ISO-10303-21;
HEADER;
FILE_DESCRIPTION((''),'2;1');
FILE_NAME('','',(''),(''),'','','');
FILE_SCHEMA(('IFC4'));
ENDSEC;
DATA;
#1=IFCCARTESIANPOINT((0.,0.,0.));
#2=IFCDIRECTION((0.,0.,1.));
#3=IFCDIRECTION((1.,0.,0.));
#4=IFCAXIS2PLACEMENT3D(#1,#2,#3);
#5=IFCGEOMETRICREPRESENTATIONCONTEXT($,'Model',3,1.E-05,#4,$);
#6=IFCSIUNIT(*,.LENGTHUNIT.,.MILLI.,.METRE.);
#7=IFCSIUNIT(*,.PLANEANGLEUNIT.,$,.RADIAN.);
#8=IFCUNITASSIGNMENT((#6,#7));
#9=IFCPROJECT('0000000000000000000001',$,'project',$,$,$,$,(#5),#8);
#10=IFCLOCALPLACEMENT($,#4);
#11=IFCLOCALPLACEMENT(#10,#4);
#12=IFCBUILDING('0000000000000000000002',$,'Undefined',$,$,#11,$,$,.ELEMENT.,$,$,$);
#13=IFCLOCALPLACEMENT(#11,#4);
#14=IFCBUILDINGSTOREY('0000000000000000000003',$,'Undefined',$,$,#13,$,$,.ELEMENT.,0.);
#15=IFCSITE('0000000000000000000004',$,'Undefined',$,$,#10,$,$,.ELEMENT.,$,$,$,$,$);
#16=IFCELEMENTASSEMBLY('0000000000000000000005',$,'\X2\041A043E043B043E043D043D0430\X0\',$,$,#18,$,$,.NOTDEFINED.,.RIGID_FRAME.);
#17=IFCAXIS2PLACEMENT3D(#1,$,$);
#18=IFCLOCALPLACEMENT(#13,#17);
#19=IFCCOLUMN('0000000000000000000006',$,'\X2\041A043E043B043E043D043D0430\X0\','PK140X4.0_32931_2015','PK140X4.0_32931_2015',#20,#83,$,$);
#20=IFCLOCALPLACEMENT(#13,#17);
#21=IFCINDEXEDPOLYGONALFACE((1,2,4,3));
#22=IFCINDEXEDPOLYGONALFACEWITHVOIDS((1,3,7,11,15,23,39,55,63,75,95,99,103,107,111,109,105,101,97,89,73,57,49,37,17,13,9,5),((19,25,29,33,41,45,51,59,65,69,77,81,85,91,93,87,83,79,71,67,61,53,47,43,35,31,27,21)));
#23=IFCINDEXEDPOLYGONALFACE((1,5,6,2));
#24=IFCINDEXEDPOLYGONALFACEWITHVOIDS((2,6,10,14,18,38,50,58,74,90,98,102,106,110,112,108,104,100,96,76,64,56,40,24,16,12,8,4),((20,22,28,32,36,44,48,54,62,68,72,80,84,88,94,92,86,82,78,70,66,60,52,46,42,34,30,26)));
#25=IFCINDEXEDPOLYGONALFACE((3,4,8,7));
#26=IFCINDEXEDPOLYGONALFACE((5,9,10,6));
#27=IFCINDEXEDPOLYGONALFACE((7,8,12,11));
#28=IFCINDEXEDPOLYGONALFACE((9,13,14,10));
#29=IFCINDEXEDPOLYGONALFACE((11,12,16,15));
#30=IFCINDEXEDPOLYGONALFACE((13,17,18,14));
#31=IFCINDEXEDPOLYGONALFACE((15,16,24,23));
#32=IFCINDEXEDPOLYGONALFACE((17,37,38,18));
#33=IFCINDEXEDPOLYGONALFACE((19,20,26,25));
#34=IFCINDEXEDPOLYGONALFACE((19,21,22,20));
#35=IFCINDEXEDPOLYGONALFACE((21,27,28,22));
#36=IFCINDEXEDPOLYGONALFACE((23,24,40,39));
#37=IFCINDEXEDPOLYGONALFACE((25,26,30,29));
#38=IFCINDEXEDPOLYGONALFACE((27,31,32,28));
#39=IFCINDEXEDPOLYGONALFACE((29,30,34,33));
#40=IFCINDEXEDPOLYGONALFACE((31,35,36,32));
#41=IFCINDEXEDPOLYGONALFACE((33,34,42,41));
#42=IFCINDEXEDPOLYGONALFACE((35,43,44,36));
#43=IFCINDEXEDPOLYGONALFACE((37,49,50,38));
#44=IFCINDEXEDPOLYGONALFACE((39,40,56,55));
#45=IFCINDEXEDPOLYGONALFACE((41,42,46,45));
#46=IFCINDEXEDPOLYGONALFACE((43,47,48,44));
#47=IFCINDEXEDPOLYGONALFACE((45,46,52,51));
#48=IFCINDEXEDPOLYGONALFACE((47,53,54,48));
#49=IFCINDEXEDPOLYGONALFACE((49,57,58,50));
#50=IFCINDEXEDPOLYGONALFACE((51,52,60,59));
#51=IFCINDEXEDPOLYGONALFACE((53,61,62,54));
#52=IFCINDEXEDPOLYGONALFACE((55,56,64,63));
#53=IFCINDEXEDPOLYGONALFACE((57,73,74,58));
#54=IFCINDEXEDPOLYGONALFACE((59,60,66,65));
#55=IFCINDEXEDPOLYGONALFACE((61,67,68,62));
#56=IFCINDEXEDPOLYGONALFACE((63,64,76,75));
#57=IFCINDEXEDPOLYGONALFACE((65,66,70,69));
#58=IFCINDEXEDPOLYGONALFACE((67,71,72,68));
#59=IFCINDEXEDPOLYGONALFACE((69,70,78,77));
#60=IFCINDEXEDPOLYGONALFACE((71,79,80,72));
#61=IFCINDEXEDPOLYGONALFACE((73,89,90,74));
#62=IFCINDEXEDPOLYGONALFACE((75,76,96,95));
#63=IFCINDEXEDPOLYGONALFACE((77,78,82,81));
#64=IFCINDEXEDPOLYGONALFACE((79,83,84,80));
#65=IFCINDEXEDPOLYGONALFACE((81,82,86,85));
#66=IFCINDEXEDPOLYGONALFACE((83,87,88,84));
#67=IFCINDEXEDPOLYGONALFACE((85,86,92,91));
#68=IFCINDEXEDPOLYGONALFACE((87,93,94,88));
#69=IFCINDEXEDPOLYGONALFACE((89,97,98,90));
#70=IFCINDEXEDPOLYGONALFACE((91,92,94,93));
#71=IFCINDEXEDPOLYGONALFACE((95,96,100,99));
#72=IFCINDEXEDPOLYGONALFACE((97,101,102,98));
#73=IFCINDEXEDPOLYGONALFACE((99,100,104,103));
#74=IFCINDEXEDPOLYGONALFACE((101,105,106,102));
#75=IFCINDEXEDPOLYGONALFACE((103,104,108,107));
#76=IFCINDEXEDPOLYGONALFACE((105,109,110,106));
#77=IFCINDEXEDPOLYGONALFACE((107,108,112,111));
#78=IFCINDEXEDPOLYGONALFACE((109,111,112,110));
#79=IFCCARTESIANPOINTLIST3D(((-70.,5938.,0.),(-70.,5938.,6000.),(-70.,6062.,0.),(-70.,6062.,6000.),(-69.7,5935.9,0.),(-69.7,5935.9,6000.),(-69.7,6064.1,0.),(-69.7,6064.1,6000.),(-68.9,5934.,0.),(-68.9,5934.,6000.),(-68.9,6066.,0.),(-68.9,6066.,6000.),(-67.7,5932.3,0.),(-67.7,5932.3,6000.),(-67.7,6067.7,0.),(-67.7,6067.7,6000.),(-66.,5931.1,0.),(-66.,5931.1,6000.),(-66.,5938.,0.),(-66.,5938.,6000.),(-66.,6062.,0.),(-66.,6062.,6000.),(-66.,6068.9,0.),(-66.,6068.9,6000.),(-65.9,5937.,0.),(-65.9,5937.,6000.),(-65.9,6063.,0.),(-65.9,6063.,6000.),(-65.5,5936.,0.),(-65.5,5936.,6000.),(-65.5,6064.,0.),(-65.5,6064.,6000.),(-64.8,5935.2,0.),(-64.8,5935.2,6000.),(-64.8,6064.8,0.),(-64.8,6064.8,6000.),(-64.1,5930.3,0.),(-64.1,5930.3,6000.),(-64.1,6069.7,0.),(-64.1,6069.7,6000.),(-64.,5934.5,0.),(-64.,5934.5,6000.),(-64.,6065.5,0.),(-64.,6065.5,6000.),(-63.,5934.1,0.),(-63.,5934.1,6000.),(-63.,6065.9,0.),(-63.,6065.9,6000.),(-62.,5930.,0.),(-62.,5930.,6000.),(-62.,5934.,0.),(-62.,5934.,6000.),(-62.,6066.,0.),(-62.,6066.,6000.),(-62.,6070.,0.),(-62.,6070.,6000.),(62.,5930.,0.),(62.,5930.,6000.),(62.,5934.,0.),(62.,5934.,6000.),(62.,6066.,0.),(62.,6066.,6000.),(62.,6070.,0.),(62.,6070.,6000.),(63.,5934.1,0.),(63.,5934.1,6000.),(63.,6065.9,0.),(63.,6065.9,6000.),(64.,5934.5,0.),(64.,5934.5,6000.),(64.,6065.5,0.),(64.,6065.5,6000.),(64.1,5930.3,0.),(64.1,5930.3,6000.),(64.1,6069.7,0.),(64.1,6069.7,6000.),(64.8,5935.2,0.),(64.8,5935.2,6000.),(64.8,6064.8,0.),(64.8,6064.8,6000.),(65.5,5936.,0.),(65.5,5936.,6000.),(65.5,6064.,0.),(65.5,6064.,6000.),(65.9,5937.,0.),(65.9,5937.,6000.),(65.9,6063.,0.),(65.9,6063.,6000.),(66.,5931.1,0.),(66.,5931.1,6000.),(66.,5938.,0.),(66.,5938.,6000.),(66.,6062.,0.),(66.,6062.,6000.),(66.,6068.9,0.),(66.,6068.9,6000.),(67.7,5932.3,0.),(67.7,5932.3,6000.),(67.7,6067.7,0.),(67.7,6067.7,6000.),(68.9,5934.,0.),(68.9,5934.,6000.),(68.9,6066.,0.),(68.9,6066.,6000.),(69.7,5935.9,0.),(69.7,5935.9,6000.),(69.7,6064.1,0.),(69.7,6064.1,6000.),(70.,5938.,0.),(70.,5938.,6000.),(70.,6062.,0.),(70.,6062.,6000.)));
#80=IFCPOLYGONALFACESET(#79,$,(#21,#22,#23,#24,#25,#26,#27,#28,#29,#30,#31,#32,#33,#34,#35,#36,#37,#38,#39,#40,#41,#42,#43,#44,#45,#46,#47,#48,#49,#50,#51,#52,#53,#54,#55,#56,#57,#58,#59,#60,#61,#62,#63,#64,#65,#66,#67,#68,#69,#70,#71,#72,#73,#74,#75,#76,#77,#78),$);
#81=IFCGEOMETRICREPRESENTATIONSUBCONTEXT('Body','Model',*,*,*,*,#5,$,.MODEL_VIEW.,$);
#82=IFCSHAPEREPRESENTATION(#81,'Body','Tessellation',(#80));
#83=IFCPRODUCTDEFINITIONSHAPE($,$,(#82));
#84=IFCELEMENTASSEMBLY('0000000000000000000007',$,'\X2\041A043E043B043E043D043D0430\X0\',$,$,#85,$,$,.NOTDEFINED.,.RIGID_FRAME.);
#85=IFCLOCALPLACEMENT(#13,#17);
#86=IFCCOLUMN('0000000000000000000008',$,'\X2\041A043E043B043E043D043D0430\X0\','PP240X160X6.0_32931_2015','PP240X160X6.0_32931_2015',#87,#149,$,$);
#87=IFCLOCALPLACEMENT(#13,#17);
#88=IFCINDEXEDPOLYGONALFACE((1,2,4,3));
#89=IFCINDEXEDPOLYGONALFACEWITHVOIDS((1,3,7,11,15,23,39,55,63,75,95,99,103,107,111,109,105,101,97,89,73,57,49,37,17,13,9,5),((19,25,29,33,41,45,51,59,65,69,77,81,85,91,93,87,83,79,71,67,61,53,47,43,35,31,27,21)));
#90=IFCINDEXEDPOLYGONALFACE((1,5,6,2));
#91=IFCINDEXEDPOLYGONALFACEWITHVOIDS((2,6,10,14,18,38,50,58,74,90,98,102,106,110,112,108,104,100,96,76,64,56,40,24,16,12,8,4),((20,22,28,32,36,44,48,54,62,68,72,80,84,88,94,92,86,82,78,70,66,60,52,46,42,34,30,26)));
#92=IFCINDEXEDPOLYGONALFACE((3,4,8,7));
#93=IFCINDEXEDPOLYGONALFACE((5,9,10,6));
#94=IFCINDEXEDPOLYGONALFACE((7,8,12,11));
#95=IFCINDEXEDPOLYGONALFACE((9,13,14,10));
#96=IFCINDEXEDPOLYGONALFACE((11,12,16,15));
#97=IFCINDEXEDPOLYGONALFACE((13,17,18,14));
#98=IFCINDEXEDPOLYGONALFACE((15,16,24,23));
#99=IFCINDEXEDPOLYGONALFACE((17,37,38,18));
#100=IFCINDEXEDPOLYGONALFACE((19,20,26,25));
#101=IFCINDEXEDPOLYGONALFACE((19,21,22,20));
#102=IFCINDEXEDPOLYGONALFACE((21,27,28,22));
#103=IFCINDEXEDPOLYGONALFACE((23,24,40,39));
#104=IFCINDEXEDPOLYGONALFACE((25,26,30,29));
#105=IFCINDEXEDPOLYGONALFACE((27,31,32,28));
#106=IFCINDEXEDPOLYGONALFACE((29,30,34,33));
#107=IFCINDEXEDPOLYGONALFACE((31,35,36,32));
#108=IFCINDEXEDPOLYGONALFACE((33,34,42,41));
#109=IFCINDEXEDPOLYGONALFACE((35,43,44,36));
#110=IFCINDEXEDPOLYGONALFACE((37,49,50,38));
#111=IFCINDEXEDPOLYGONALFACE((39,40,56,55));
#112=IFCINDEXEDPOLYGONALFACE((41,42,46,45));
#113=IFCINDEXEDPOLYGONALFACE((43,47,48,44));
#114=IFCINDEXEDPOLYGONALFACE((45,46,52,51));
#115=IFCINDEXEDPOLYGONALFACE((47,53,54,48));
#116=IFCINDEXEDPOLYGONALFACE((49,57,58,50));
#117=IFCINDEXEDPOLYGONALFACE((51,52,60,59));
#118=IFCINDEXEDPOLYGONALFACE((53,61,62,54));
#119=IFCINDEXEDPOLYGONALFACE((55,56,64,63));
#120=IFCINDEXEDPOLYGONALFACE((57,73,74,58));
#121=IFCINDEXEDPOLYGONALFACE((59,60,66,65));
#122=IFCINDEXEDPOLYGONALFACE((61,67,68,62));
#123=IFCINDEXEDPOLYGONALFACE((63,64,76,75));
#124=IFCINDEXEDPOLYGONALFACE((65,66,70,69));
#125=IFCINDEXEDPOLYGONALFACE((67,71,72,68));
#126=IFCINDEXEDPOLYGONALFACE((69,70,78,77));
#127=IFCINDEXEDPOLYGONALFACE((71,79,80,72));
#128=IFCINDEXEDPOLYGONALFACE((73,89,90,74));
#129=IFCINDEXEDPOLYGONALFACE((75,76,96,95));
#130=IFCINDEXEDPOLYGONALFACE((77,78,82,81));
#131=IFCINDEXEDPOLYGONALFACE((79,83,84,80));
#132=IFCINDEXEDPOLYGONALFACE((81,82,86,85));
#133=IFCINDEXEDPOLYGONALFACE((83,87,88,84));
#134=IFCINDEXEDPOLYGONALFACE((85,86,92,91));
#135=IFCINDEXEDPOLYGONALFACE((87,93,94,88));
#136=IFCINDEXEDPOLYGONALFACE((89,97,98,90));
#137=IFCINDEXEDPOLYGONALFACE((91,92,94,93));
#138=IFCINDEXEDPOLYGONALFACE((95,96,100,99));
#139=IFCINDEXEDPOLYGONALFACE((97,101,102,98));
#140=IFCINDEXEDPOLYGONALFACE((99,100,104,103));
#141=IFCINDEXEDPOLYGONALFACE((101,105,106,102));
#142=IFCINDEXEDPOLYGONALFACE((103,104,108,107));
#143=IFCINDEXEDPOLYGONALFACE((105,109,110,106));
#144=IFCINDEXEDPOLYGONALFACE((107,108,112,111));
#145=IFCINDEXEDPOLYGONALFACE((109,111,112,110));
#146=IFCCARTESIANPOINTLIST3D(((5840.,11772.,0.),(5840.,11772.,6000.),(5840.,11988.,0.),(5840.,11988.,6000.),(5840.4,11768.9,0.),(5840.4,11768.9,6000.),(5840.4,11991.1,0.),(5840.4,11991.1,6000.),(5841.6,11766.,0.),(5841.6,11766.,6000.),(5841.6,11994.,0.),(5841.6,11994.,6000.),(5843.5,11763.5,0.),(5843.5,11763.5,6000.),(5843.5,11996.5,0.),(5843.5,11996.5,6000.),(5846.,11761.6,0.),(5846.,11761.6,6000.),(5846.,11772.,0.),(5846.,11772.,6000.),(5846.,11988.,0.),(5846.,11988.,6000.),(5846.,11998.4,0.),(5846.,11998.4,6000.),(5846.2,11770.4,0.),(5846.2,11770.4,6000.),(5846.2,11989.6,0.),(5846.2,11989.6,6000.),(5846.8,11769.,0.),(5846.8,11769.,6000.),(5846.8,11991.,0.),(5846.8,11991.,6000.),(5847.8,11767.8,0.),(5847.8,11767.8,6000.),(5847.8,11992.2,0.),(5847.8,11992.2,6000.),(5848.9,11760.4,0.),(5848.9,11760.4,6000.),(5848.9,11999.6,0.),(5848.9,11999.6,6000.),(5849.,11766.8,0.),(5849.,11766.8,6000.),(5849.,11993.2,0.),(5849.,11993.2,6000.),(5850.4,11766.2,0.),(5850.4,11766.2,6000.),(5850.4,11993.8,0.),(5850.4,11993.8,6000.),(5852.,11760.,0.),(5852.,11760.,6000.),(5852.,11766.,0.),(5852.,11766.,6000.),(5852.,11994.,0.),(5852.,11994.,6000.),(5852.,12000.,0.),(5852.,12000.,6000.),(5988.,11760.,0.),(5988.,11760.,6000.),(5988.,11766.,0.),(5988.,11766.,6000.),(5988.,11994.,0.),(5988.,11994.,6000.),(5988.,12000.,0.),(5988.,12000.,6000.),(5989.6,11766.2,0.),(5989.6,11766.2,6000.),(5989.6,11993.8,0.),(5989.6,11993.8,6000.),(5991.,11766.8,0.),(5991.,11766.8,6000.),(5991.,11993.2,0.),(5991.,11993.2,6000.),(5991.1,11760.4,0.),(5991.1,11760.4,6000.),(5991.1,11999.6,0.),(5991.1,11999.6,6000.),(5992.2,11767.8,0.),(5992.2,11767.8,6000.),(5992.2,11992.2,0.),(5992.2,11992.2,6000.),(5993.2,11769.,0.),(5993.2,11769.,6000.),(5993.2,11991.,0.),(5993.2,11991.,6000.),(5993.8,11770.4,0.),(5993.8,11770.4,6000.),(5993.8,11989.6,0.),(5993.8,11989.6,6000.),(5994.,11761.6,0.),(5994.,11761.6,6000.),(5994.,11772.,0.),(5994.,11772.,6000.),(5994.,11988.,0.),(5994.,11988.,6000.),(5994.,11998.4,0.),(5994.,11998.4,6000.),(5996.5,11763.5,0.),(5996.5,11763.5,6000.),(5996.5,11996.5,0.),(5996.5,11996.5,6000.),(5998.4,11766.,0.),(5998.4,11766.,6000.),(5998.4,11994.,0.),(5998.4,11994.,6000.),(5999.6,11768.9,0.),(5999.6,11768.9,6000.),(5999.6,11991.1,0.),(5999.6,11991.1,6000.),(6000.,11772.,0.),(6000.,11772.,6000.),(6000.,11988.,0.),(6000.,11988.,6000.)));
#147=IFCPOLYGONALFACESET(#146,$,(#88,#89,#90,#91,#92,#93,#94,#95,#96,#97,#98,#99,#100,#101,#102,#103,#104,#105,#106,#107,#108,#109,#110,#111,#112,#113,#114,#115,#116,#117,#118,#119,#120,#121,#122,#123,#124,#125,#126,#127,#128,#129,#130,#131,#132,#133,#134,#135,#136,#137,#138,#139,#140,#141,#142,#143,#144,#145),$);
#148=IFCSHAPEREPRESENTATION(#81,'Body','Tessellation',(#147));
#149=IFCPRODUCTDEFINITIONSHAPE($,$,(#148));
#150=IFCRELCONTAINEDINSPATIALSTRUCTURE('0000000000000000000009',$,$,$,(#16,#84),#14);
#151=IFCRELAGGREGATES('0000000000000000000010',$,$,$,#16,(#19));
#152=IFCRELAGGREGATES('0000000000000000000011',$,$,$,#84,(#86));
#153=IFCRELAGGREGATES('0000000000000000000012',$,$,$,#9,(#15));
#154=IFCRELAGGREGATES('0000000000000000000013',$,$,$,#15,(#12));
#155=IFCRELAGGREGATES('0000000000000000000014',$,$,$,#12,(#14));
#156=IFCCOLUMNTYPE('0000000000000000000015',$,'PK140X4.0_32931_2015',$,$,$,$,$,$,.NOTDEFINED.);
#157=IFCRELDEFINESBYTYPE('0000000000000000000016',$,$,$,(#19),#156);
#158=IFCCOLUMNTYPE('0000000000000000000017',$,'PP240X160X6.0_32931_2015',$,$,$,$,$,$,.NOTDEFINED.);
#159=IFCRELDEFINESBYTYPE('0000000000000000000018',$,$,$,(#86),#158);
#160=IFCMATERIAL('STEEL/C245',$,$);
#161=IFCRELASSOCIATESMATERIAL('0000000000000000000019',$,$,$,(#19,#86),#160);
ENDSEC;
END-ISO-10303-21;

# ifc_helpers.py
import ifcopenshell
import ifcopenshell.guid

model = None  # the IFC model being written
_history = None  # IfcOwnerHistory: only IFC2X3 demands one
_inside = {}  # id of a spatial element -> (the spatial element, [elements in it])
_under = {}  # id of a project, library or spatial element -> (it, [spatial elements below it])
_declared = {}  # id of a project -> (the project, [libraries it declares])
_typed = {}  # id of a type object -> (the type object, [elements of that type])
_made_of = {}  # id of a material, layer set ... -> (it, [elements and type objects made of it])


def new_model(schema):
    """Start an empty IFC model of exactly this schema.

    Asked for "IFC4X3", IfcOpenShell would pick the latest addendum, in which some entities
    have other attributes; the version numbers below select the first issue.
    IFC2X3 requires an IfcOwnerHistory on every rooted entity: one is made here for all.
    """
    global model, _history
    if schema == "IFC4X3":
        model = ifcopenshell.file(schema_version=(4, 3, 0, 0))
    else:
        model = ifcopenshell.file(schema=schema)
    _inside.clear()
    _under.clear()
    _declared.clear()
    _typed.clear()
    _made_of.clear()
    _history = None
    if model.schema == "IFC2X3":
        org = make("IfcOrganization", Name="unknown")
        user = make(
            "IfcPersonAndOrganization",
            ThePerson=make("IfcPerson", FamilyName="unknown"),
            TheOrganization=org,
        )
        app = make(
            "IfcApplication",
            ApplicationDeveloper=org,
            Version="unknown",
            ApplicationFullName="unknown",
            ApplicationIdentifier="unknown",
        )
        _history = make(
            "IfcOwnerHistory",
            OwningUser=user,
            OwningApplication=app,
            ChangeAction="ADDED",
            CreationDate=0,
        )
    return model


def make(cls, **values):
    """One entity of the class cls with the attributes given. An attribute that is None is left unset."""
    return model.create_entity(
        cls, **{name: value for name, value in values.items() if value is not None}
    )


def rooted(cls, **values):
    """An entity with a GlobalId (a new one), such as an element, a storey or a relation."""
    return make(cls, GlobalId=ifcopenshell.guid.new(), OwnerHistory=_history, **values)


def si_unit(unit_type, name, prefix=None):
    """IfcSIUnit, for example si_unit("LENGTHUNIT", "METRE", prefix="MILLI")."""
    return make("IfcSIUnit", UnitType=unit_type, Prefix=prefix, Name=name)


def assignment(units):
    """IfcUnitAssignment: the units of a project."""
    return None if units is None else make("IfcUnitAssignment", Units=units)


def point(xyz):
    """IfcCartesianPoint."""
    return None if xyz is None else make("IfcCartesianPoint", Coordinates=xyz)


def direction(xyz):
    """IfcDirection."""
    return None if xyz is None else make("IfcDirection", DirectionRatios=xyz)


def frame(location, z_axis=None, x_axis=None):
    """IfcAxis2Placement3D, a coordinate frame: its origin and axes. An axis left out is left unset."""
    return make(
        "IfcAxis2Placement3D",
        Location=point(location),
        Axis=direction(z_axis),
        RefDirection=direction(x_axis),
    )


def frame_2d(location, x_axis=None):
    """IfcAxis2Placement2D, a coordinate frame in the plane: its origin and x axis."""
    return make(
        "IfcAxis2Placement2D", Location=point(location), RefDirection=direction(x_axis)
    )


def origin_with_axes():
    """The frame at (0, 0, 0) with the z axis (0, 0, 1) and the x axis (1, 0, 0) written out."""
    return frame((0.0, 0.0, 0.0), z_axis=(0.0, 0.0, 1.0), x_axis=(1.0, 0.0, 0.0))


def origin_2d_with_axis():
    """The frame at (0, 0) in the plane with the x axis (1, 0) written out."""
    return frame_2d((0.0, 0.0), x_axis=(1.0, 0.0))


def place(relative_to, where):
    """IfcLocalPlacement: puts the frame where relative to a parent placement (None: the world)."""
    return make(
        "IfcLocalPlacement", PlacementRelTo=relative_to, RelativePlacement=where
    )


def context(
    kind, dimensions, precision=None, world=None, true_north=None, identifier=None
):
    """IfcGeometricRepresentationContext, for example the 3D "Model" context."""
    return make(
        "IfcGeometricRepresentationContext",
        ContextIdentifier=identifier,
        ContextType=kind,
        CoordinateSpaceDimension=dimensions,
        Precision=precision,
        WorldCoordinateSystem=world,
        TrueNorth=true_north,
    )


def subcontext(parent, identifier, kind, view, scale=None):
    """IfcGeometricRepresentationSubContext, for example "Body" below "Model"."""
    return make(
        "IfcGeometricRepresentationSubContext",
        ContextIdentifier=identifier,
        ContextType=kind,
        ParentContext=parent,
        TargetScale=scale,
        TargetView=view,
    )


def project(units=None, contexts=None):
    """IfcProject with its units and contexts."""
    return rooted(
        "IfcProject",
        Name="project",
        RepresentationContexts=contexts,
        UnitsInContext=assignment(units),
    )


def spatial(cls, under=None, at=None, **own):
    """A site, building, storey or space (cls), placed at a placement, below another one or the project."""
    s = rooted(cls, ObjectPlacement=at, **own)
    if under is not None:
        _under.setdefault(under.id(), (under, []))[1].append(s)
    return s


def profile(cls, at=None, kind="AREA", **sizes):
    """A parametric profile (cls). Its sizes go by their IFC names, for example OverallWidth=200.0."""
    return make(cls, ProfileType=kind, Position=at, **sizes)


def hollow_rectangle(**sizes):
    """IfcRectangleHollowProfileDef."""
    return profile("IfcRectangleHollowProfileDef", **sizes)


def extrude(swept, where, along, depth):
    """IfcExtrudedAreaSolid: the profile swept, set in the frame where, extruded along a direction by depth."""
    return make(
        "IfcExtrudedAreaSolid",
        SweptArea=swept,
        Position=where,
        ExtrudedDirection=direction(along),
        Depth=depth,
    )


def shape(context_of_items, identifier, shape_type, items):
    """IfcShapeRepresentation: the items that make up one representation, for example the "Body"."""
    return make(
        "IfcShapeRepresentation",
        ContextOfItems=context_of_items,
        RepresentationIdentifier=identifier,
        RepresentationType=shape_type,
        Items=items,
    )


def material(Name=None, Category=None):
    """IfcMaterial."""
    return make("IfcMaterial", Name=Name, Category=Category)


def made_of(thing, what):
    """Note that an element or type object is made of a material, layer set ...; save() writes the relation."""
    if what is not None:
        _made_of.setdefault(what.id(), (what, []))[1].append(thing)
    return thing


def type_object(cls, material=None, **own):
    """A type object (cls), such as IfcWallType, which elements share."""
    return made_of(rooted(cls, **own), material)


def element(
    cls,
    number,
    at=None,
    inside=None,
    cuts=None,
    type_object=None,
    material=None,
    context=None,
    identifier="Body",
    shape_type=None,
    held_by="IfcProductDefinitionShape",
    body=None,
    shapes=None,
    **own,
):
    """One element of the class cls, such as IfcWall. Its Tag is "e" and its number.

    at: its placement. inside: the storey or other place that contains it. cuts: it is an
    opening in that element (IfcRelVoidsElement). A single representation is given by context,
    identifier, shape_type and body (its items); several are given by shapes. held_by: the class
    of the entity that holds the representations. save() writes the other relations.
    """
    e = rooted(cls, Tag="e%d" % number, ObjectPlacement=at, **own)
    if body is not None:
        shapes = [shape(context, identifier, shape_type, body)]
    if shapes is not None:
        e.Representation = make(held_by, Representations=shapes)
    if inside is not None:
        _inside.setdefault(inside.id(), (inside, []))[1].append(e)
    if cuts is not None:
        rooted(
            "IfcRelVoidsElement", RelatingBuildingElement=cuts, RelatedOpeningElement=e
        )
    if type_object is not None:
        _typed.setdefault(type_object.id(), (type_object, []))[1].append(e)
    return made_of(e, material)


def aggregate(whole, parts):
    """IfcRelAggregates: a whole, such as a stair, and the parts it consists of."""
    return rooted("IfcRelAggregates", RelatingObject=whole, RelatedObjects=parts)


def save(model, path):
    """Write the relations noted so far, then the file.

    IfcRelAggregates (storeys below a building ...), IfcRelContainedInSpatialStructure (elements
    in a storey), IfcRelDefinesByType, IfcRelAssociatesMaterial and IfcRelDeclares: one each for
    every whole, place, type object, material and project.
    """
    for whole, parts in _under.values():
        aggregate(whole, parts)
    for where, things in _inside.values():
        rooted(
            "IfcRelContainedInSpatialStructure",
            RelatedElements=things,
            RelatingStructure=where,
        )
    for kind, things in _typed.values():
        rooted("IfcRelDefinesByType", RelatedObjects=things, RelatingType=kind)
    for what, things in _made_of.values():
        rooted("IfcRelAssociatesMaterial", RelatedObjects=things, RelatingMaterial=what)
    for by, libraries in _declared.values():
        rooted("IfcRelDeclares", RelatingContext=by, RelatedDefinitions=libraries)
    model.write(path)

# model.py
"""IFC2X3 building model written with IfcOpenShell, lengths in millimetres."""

from ifc_helpers import new_model, si_unit, frame, origin_with_axes, origin_2d_with_axis, place, context, subcontext, project, spatial, hollow_rectangle, extrude, material, type_object, element, aggregate, save


model = new_model("IFC2X3")

# Units and contexts
model_context = context("Model", 3, precision=1e-05, world=origin_with_axes())
body_context = subcontext(model_context, "Body", "Model", "MODEL_VIEW")
ifc_project = project(units=[si_unit("LENGTHUNIT", "METRE", prefix="MILLI"), si_unit("PLANEANGLEUNIT", "RADIAN")], contexts=[model_context])

# Site, building, storey
site_placement = place(None, origin_with_axes())
site = spatial("IfcSite", under=ifc_project, at=site_placement, Name="Undefined", CompositionType="ELEMENT")
building_placement = place(site_placement, origin_with_axes())
building = spatial("IfcBuilding", under=site, at=building_placement, Name="Undefined", CompositionType="ELEMENT")
storey_placement = place(building_placement, origin_with_axes())
storey = spatial("IfcBuildingStorey", under=building, at=storey_placement, Name="Undefined", CompositionType="ELEMENT", Elevation=0.0)

# Element assemblies, columns
assembly_1_placement = place(storey_placement, origin_with_axes())
assembly_1 = element("IfcElementAssembly", 1, at=assembly_1_placement, inside=storey, Name="Колонна", AssemblyPlace="NOTDEFINED", PredefinedType="RIGID_FRAME")
ifc_material = material(Name="STEEL/C245")
column_type_1 = type_object("IfcColumnType", Name="PK140X4.0_32931_2015", PredefinedType="NOTDEFINED")
column_1_placement = place(assembly_1_placement, frame((0.0, 6000.0, 0.0), z_axis=(0.0, 0.0, 1.0), x_axis=(0.0, 1.0, 0.0)))
column_1 = element("IfcColumn", 2, at=column_1_placement, type_object=column_type_1, material=ifc_material, Name="Колонна", Description="PK140X4.0_32931_2015", ObjectType="PK140X4.0_32931_2015", context=body_context, shape_type="SweptSolid", body=[
    extrude(hollow_rectangle(XDim=140.0, YDim=140.0, WallThickness=4.0, InnerFilletRadius=4.0, OuterFilletRadius=8.0, at=origin_2d_with_axis()), frame((0.0, 0.0, 6000.0), z_axis=(0.0, 0.0, -1.0), x_axis=(0.0, 1.0, 0.0)), (0.0, 0.0, 1.0), 6000.0),
])
aggregate(assembly_1, [column_1])
assembly_2_placement = place(storey_placement, origin_with_axes())
assembly_2 = element("IfcElementAssembly", 3, at=assembly_2_placement, inside=storey, Name="Колонна", AssemblyPlace="NOTDEFINED", PredefinedType="RIGID_FRAME")
column_type_2 = type_object("IfcColumnType", Name="PP240X160X6.0_32931_2015", PredefinedType="NOTDEFINED")
column_2_placement = place(assembly_2_placement, frame((5920.0, 11880.0, 0.0), z_axis=(0.0, 0.0, 1.0), x_axis=(0.0, -1.0, 0.0)))
column_2 = element("IfcColumn", 4, at=column_2_placement, type_object=column_type_2, material=ifc_material, Name="Колонна", Description="PP240X160X6.0_32931_2015", ObjectType="PP240X160X6.0_32931_2015", context=body_context, shape_type="SweptSolid", body=[
    extrude(hollow_rectangle(XDim=160.0, YDim=240.0, WallThickness=6.0, InnerFilletRadius=6.0, OuterFilletRadius=12.0, at=origin_2d_with_axis()), frame((0.0, 0.0, 6000.0), z_axis=(0.0, 0.0, -1.0), x_axis=(0.0, 1.0, 0.0)), (0.0, 0.0, 1.0), 6000.0),
])
aggregate(assembly_2, [column_2])

save(model, "model.ifc")
